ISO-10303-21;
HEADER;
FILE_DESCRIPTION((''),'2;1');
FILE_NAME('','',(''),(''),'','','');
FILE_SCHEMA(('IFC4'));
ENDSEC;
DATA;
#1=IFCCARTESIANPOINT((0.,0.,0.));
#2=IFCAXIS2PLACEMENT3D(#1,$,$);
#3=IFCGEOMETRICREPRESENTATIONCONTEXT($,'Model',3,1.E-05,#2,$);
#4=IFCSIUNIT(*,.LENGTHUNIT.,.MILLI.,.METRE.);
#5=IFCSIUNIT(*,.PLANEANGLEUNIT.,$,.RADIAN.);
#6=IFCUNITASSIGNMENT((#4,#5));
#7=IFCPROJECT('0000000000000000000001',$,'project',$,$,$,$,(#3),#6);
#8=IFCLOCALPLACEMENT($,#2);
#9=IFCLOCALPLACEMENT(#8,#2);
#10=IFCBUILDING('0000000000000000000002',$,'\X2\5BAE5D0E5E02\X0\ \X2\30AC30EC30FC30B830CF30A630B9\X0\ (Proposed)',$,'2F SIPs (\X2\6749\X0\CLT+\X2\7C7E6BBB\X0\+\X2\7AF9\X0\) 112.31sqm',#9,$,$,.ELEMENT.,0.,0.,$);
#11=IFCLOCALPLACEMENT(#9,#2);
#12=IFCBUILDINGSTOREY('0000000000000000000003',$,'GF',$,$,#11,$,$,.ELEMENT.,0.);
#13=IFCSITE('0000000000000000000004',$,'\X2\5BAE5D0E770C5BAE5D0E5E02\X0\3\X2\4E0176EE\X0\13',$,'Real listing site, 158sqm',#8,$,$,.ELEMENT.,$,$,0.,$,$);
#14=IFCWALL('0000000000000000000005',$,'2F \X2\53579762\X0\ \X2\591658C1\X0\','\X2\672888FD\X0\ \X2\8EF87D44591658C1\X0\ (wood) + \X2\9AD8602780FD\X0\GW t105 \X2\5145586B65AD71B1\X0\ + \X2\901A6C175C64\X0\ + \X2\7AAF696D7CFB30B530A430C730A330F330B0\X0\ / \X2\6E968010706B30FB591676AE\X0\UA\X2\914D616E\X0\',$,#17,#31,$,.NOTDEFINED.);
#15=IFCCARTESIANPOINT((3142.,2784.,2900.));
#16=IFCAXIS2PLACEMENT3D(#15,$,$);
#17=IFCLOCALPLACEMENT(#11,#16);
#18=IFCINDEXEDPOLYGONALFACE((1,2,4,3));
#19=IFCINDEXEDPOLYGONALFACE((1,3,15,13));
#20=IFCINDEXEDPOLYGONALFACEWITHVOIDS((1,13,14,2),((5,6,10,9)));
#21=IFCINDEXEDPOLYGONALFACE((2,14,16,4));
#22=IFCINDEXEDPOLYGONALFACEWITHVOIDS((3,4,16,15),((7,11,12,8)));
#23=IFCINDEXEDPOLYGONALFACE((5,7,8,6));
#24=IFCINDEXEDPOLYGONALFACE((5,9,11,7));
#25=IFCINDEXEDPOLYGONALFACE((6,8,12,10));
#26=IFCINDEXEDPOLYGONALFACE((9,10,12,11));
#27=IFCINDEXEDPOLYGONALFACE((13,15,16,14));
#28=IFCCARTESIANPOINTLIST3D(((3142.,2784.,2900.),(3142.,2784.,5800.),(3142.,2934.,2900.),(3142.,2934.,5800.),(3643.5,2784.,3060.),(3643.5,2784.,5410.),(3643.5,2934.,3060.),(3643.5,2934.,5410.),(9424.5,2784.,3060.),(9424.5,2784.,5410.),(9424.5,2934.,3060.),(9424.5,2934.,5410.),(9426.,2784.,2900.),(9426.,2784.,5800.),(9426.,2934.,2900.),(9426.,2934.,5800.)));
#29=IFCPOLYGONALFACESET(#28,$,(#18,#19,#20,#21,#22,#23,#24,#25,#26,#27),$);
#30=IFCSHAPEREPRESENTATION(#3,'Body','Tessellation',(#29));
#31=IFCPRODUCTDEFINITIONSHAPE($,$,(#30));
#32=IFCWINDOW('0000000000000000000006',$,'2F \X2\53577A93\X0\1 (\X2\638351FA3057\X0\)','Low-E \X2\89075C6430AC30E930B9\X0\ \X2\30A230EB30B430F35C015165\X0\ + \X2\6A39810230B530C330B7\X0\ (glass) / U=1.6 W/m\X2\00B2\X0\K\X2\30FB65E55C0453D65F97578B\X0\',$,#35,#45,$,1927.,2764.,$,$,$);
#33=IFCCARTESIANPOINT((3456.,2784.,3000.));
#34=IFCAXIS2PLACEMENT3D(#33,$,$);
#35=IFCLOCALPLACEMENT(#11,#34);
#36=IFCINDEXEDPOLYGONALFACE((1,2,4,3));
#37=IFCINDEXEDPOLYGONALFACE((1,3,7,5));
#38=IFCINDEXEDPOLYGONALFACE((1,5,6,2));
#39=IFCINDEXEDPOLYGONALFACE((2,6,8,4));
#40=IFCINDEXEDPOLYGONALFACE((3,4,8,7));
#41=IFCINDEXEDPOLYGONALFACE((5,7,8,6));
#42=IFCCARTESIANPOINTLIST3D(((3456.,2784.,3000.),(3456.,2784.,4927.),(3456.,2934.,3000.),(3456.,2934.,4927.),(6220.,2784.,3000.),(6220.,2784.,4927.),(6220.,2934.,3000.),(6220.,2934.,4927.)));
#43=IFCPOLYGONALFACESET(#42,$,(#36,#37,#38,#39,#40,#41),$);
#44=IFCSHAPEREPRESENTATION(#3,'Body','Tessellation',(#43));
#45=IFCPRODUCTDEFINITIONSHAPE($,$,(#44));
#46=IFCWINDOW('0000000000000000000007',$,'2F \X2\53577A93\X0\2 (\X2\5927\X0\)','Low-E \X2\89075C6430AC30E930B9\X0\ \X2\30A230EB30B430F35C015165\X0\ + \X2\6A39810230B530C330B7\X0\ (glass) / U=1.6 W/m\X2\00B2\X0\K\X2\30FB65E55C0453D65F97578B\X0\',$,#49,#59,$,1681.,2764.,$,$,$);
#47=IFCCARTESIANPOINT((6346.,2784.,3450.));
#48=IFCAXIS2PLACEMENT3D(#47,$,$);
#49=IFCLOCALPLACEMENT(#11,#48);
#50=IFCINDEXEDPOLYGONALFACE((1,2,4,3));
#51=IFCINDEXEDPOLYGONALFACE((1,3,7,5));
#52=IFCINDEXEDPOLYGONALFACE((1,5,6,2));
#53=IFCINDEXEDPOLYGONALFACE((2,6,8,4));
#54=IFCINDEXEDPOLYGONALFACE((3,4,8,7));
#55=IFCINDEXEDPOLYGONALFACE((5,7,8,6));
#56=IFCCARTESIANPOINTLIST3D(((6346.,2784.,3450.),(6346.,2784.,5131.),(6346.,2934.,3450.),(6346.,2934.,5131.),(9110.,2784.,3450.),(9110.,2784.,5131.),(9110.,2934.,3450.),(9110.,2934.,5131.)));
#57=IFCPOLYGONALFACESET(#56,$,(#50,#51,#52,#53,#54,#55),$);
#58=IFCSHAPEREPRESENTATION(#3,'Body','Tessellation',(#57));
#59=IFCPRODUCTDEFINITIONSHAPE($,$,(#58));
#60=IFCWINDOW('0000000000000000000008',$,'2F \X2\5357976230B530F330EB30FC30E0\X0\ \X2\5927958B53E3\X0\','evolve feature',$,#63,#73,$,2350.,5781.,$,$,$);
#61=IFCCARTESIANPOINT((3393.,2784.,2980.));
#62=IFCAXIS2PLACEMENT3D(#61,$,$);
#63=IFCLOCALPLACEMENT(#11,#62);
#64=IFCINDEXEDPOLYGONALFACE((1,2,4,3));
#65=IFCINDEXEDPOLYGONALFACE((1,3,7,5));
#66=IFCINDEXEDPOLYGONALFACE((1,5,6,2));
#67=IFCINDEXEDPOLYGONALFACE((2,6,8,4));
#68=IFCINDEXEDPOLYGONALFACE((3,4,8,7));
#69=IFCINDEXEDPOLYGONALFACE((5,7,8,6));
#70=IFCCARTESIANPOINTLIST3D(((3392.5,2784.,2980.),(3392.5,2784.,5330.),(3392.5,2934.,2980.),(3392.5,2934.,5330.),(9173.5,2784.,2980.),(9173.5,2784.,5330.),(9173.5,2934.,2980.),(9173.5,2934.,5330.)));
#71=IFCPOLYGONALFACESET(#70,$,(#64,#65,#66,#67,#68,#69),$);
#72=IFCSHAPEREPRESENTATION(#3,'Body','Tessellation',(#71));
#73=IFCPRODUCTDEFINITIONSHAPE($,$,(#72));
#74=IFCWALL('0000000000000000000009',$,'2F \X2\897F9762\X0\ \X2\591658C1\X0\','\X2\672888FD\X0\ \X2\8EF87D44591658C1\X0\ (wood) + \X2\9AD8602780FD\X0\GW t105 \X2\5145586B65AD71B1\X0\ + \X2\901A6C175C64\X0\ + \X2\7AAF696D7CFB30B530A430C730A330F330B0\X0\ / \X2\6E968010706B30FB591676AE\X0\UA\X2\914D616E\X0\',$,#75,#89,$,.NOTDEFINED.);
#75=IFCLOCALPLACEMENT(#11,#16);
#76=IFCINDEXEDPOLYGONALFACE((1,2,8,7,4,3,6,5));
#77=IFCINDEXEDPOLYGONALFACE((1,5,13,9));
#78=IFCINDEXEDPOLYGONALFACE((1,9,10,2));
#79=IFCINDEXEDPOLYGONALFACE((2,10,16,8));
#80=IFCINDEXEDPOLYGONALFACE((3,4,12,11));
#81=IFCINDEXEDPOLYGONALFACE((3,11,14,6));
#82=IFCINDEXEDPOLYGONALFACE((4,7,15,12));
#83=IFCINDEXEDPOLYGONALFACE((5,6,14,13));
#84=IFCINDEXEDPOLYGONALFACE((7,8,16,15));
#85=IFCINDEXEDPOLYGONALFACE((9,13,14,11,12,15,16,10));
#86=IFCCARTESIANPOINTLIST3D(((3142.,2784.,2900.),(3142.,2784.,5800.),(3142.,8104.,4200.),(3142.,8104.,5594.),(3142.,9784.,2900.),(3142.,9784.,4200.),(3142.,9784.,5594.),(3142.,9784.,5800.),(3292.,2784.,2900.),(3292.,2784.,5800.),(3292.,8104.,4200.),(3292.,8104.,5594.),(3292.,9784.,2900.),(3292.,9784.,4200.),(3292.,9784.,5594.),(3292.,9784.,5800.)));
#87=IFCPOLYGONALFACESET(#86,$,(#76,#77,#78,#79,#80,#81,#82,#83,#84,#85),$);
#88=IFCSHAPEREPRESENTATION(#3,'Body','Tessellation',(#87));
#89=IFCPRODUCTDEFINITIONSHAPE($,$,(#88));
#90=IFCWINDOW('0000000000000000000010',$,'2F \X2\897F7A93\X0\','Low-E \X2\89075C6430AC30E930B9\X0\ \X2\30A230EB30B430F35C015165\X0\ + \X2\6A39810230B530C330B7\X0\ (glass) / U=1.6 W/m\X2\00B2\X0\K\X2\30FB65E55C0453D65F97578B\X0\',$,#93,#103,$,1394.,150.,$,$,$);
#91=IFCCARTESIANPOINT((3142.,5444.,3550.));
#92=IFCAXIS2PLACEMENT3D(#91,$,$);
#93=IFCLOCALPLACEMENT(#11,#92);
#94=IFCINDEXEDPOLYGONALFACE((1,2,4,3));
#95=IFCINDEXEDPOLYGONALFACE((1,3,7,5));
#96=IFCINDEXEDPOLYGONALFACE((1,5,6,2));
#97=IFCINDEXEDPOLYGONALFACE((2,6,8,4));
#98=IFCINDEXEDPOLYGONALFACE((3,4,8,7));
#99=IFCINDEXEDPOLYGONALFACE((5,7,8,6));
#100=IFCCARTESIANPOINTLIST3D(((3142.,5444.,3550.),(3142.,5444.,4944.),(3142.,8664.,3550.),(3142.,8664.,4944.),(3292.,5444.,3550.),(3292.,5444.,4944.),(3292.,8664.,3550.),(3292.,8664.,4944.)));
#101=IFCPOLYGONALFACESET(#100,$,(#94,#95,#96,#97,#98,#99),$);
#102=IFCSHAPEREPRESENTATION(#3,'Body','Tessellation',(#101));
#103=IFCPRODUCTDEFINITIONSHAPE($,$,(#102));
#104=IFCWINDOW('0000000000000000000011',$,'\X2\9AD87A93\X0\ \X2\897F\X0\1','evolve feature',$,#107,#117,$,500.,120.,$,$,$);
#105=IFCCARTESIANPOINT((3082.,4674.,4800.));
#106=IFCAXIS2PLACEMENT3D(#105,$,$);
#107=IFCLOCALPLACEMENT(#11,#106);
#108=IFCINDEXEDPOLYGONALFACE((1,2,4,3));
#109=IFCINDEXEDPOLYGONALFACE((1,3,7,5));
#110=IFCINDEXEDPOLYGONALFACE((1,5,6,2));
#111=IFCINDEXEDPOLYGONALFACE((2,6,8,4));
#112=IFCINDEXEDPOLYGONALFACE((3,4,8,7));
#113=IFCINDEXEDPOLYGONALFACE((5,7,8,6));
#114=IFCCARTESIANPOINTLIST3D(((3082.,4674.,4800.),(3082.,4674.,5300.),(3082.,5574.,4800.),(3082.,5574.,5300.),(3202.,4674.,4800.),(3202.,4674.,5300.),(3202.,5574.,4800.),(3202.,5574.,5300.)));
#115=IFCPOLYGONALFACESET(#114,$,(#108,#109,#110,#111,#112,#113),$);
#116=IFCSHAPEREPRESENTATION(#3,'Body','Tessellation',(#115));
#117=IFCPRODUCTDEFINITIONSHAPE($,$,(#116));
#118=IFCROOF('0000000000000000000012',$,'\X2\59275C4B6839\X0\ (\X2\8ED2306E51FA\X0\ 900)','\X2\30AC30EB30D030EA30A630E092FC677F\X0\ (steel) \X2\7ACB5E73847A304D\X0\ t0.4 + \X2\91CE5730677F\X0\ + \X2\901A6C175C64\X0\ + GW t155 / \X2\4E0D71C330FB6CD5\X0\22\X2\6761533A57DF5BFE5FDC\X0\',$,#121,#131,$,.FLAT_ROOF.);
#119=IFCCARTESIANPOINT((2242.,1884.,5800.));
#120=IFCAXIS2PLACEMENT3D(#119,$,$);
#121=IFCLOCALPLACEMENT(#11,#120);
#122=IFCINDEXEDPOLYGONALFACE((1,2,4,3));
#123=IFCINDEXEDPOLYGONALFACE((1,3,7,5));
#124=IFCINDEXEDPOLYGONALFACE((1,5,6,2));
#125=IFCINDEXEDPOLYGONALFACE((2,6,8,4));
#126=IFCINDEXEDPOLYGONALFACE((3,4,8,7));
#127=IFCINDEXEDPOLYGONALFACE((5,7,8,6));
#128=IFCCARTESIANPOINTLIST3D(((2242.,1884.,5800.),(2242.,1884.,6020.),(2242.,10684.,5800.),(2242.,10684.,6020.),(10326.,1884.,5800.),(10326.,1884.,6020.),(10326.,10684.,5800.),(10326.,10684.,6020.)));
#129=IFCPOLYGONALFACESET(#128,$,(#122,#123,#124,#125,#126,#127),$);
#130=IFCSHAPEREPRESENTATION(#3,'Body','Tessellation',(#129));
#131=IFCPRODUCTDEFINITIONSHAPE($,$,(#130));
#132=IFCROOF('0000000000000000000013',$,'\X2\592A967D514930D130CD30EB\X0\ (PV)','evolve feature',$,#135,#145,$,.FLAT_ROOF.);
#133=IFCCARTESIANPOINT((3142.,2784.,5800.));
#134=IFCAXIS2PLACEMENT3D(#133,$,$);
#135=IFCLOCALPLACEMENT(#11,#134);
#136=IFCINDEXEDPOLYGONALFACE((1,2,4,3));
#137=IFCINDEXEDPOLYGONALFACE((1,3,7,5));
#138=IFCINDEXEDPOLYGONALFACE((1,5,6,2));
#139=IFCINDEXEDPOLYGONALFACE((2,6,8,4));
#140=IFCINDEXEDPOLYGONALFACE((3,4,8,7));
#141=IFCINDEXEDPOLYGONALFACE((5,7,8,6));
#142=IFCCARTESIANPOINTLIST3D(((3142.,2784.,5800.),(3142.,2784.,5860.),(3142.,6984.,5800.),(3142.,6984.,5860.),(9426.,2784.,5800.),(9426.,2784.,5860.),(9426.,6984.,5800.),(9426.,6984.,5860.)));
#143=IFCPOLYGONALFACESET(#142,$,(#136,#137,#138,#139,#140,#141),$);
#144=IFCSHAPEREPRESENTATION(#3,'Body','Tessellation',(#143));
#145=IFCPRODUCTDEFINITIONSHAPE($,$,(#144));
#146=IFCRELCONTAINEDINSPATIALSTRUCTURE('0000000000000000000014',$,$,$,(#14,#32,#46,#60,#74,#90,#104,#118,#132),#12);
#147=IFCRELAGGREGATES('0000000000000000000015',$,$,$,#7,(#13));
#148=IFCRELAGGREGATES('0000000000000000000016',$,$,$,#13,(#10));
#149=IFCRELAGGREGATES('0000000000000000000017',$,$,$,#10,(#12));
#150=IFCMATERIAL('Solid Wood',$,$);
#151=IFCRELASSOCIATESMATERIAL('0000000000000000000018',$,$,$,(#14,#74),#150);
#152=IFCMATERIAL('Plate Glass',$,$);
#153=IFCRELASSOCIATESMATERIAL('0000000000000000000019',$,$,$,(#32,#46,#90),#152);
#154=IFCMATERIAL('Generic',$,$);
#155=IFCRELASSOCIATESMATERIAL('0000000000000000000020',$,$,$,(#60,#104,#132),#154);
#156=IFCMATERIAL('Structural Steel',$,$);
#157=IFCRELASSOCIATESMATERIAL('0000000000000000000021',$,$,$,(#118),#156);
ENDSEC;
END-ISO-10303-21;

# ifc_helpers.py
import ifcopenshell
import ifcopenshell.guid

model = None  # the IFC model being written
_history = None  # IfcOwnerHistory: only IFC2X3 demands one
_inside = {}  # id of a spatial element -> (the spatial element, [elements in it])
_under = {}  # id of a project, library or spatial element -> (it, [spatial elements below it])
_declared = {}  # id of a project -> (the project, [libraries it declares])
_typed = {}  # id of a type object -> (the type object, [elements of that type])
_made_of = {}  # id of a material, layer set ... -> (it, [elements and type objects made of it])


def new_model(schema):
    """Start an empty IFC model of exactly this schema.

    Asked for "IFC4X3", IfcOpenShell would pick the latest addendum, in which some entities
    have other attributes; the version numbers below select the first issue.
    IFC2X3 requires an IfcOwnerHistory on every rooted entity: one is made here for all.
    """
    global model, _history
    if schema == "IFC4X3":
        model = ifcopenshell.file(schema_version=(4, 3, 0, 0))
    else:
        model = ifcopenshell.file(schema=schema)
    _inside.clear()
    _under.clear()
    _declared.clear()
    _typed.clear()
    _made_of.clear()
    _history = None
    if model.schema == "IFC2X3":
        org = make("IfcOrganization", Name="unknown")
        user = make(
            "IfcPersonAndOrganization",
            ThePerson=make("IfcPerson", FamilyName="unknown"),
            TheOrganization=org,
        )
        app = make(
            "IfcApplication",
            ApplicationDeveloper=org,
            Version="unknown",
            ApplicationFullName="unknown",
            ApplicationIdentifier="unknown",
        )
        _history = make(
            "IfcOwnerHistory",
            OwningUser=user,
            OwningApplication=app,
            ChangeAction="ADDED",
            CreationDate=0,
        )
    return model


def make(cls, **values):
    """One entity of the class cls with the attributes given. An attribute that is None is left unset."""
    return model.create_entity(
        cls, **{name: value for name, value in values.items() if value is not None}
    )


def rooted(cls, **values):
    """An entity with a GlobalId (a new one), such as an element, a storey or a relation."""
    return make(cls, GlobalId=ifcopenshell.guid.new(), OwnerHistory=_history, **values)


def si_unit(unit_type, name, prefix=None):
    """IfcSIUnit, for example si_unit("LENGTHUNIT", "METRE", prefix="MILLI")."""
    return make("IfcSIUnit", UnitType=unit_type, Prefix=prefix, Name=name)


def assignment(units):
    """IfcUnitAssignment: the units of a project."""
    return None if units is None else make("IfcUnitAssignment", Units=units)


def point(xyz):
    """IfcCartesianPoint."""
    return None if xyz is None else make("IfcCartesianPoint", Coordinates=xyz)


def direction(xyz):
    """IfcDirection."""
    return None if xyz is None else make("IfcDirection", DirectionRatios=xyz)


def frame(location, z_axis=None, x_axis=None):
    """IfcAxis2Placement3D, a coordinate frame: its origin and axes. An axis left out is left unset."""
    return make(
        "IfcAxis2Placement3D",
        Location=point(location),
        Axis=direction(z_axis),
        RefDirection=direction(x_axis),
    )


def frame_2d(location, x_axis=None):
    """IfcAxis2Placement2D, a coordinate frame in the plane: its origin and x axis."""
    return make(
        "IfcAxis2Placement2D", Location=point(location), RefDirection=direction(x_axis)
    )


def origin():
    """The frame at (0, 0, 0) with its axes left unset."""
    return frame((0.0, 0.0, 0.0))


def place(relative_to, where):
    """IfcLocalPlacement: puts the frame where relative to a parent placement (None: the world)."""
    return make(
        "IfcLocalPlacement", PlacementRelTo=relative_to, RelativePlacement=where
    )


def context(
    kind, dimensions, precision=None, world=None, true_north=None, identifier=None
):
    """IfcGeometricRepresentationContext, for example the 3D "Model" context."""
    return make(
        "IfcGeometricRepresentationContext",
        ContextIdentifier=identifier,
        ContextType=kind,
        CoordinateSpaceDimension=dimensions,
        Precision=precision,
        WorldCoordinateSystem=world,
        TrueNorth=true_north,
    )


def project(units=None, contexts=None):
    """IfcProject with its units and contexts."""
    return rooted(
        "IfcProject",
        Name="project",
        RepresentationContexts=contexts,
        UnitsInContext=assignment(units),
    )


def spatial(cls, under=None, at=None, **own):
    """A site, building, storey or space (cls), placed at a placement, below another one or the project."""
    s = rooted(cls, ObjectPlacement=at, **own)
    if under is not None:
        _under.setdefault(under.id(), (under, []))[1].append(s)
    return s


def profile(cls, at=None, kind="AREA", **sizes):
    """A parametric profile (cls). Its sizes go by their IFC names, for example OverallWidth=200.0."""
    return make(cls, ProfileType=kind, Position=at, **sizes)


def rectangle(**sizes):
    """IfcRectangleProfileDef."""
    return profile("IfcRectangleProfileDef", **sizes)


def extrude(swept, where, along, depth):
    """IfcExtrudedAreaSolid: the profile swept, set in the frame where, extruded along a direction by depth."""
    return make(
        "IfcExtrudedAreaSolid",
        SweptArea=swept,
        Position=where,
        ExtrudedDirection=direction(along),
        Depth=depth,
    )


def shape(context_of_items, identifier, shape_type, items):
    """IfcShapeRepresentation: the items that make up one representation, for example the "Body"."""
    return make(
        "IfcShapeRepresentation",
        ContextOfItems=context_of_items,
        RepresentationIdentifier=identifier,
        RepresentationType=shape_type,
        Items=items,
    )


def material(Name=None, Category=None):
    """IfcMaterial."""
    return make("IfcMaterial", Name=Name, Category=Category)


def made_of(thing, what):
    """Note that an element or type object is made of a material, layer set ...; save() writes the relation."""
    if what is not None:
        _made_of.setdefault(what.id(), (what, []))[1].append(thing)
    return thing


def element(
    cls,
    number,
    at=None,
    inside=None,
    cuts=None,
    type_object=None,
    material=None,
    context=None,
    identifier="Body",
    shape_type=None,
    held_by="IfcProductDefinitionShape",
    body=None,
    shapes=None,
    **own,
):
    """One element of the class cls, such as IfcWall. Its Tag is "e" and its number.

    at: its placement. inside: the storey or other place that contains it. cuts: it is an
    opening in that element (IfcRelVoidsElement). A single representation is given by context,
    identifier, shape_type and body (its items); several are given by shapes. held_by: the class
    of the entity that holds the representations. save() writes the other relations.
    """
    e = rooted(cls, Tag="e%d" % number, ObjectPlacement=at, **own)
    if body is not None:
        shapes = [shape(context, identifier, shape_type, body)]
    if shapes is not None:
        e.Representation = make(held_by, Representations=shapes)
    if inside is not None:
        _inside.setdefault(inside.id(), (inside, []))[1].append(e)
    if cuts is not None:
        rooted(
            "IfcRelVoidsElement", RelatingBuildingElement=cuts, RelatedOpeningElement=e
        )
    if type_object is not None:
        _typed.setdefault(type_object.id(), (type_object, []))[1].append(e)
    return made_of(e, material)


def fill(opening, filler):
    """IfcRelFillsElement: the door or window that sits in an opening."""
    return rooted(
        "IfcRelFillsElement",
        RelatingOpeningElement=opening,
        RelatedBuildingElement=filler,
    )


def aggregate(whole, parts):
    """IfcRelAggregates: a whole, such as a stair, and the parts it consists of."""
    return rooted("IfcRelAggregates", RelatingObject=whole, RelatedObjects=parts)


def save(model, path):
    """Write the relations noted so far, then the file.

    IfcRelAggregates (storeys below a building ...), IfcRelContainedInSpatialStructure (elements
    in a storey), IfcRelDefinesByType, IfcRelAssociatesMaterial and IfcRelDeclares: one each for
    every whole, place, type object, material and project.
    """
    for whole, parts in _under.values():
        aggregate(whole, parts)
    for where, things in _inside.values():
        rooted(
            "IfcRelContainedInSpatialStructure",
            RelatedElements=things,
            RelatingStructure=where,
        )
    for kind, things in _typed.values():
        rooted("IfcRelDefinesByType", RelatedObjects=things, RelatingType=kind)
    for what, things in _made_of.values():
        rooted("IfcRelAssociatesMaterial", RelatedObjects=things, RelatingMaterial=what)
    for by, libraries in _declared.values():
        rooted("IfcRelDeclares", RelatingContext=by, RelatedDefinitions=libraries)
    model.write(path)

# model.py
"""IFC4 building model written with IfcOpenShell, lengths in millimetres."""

from ifc_helpers import new_model, si_unit, frame, frame_2d, origin, place, context, project, spatial, rectangle, extrude, material, element, fill, save


model = new_model("IFC4")

# Units and contexts
model_context = context("Model", 3, precision=1e-05, world=origin())
ifc_project = project(units=[si_unit("LENGTHUNIT", "METRE", prefix="MILLI"), si_unit("PLANEANGLEUNIT", "RADIAN")], contexts=[model_context])

# Site, building, storey
site_placement = place(None, origin())
site = spatial("IfcSite", under=ifc_project, at=site_placement, Name="宮崎県宮崎市3丁目13", ObjectType="Real listing site, 158sqm", CompositionType="ELEMENT", RefElevation=0.0)
building_placement = place(site_placement, origin())
building = spatial("IfcBuilding", under=site, at=building_placement, Name="宮崎市 ガレージハウス (Proposed)", ObjectType="2F SIPs (杉CLT+籾殻+竹) 112.31sqm", CompositionType="ELEMENT", ElevationOfRefHeight=0.0, ElevationOfTerrain=0.0)
storey_placement = place(building_placement, origin())
storey = spatial("IfcBuildingStorey", under=building, at=storey_placement, Name="GF", CompositionType="ELEMENT", Elevation=0.0)

# Shared definitions
ifc_material_1 = material(Name="Solid Wood")
ifc_material_2 = material(Name="Generic")

# Shared definitions
ifc_material_3 = material(Name="Plate Glass")

# Walls, openings, windows
wall_1_placement = place(storey_placement, frame((3142.0, 2784.0, 2900.0)))
wall_1 = element("IfcWall", 1, at=wall_1_placement, inside=storey, material=ifc_material_1, Name="2F 南面 外壁", Description="木製 軸組外壁 (wood) + 高性能GW t105 充填断熱 + 通気層 + 窯業系サイディング / 準耐火・外皮UA配慮", PredefinedType="NOTDEFINED", context=model_context, shape_type="SweptSolid", body=[
    extrude(rectangle(XDim=6284.0, YDim=150.0, at=frame_2d((3142.0, 75.0))), frame((3142.0, 2784.0, 2900.0)), (0.0, 0.0, 1.0), 2900.0),
])
opening_1_placement = place(storey_placement, frame((3456.0, 2784.0, 3000.0)))
opening_1 = element("IfcOpeningElement", 2, at=opening_1_placement, cuts=wall_1, PredefinedType="NOTDEFINED", context=model_context, shape_type="SweptSolid", body=[
    extrude(rectangle(XDim=2764.0, YDim=150.0, at=frame_2d((1382.0, 75.0))), frame((3456.0, 2784.0, 3000.0)), (0.0, 0.0, 1.0), 1927.0),
])
opening_2_placement = place(storey_placement, frame((6346.0, 2784.0, 3450.0)))
opening_2 = element("IfcOpeningElement", 3, at=opening_2_placement, cuts=wall_1, PredefinedType="NOTDEFINED", context=model_context, shape_type="SweptSolid", body=[
    extrude(rectangle(XDim=2764.0, YDim=150.0, at=frame_2d((1382.0, 75.0))), frame((6346.0, 2784.0, 3450.0)), (0.0, 0.0, 1.0), 1681.0),
])
opening_3_placement = place(storey_placement, frame((3393.0, 2784.0, 2980.0)))
opening_3 = element("IfcOpeningElement", 4, at=opening_3_placement, cuts=wall_1, PredefinedType="NOTDEFINED", context=model_context, shape_type="SweptSolid", body=[
    extrude(rectangle(XDim=5781.0, YDim=150.0, at=frame_2d((2890.0, 75.0))), frame((3393.0, 2784.0, 2980.0)), (0.0, 0.0, 1.0), 2350.0),
])
window_1_placement = place(storey_placement, frame((3456.0, 2784.0, 3000.0)))
window_1 = element("IfcWindow", 5, at=window_1_placement, inside=storey, material=ifc_material_3, Name="2F 南窓1 (掃出し)", Description="Low-E 複層ガラス アルゴン封入 + 樹脂サッシ (glass) / U=1.6 W/m²K・日射取得型", OverallHeight=1927.0, OverallWidth=2764.0, context=model_context, shape_type="SweptSolid", body=[
    extrude(rectangle(XDim=2764.0, YDim=150.0, at=frame_2d((1382.0, 75.0))), frame((3456.0, 2784.0, 3000.0)), (0.0, 0.0, 1.0), 1927.0),
])
fill(opening_1, window_1)
window_2_placement = place(storey_placement, frame((6346.0, 2784.0, 3450.0)))
window_2 = element("IfcWindow", 6, at=window_2_placement, inside=storey, material=ifc_material_3, Name="2F 南窓2 (大)", Description="Low-E 複層ガラス アルゴン封入 + 樹脂サッシ (glass) / U=1.6 W/m²K・日射取得型", OverallHeight=1681.0, OverallWidth=2764.0, context=model_context, shape_type="SweptSolid", body=[
    extrude(rectangle(XDim=2764.0, YDim=150.0, at=frame_2d((1382.0, 75.0))), frame((6346.0, 2784.0, 3450.0)), (0.0, 0.0, 1.0), 1681.0),
])
fill(opening_2, window_2)
window_3_placement = place(storey_placement, frame((3393.0, 2784.0, 2980.0)))
window_3 = element("IfcWindow", 7, at=window_3_placement, inside=storey, material=ifc_material_2, Name="2F 南面サンルーム 大開口", Description="evolve feature", OverallHeight=2350.0, OverallWidth=5781.0, context=model_context, shape_type="SweptSolid", body=[
    extrude(rectangle(XDim=5781.0, YDim=150.0, at=frame_2d((2890.0, 75.0))), frame((3393.0, 2784.0, 2980.0)), (0.0, 0.0, 1.0), 2350.0),
])
fill(opening_3, window_3)
wall_2_placement = place(storey_placement, frame((3142.0, 2784.0, 2900.0)))
wall_2 = element("IfcWall", 8, at=wall_2_placement, inside=storey, material=ifc_material_1, Name="2F 西面 外壁", Description="木製 軸組外壁 (wood) + 高性能GW t105 充填断熱 + 通気層 + 窯業系サイディング / 準耐火・外皮UA配慮", PredefinedType="NOTDEFINED", context=model_context, shape_type="SweptSolid", body=[
    extrude(rectangle(XDim=150.0, YDim=7000.0, at=frame_2d((75.0, 3500.0))), frame((3142.0, 2784.0, 2900.0)), (0.0, 0.0, 1.0), 2900.0),
])
opening_4_placement = place(storey_placement, frame((3142.0, 5444.0, 3550.0)))
opening_4 = element("IfcOpeningElement", 9, at=opening_4_placement, cuts=wall_2, PredefinedType="NOTDEFINED", context=model_context, shape_type="SweptSolid", body=[
    extrude(rectangle(XDim=150.0, YDim=3220.0, at=frame_2d((75.0, 1610.0))), frame((3142.0, 5444.0, 3550.0)), (0.0, 0.0, 1.0), 1394.0),
])
opening_5_placement = place(storey_placement, frame((3082.0, 4674.0, 4800.0)))
opening_5 = element("IfcOpeningElement", 10, at=opening_5_placement, cuts=wall_2, PredefinedType="NOTDEFINED", context=model_context, shape_type="SweptSolid", body=[
    extrude(rectangle(XDim=120.0, YDim=900.0, at=frame_2d((60.0, 450.0))), frame((3082.0, 4674.0, 4800.0)), (0.0, 0.0, 1.0), 500.0),
])
window_4_placement = place(storey_placement, frame((3142.0, 5444.0, 3550.0)))
window_4 = element("IfcWindow", 11, at=window_4_placement, inside=storey, material=ifc_material_3, Name="2F 西窓", Description="Low-E 複層ガラス アルゴン封入 + 樹脂サッシ (glass) / U=1.6 W/m²K・日射取得型", OverallHeight=1394.0, OverallWidth=150.0, context=model_context, shape_type="SweptSolid", body=[
    extrude(rectangle(XDim=150.0, YDim=3220.0, at=frame_2d((75.0, 1610.0))), frame((3142.0, 5444.0, 3550.0)), (0.0, 0.0, 1.0), 1394.0),
])
fill(opening_4, window_4)
window_5_placement = place(storey_placement, frame((3082.0, 4674.0, 4800.0)))
window_5 = element("IfcWindow", 12, at=window_5_placement, inside=storey, material=ifc_material_2, Name="高窓 西1", Description="evolve feature", OverallHeight=500.0, OverallWidth=120.0, context=model_context, shape_type="SweptSolid", body=[
    extrude(rectangle(XDim=120.0, YDim=900.0, at=frame_2d((60.0, 450.0))), frame((3082.0, 4674.0, 4800.0)), (0.0, 0.0, 1.0), 500.0),
])
fill(opening_5, window_5)

# Roofs
ifc_material_4 = material(Name="Structural Steel")
roof_1_placement = place(storey_placement, frame((2242.0, 1884.0, 5800.0)))
element("IfcRoof", 13, at=roof_1_placement, inside=storey, material=ifc_material_4, Name="大屋根 (軒の出 900)", Description="ガルバリウム鋼板 (steel) 立平葺き t0.4 + 野地板 + 通気層 + GW t155 / 不燃・法22条区域対応", PredefinedType="FLAT_ROOF", context=model_context, shape_type="SweptSolid", body=[
    extrude(rectangle(XDim=8084.0, YDim=8800.0, at=frame_2d((4042.0, 4400.0))), frame((2242.0, 1884.0, 5800.0)), (0.0, 0.0, 1.0), 220.0),
])
roof_2_placement = place(storey_placement, frame((3142.0, 2784.0, 5800.0)))
element("IfcRoof", 14, at=roof_2_placement, inside=storey, material=ifc_material_2, Name="太陽光パネル (PV)", Description="evolve feature", PredefinedType="FLAT_ROOF", context=model_context, shape_type="SweptSolid", body=[
    extrude(rectangle(XDim=6284.0, YDim=4200.0, at=frame_2d((3142.0, 2100.0))), frame((3142.0, 2784.0, 5800.0)), (0.0, 0.0, 1.0), 60.0),
])

save(model, "model.ifc")
